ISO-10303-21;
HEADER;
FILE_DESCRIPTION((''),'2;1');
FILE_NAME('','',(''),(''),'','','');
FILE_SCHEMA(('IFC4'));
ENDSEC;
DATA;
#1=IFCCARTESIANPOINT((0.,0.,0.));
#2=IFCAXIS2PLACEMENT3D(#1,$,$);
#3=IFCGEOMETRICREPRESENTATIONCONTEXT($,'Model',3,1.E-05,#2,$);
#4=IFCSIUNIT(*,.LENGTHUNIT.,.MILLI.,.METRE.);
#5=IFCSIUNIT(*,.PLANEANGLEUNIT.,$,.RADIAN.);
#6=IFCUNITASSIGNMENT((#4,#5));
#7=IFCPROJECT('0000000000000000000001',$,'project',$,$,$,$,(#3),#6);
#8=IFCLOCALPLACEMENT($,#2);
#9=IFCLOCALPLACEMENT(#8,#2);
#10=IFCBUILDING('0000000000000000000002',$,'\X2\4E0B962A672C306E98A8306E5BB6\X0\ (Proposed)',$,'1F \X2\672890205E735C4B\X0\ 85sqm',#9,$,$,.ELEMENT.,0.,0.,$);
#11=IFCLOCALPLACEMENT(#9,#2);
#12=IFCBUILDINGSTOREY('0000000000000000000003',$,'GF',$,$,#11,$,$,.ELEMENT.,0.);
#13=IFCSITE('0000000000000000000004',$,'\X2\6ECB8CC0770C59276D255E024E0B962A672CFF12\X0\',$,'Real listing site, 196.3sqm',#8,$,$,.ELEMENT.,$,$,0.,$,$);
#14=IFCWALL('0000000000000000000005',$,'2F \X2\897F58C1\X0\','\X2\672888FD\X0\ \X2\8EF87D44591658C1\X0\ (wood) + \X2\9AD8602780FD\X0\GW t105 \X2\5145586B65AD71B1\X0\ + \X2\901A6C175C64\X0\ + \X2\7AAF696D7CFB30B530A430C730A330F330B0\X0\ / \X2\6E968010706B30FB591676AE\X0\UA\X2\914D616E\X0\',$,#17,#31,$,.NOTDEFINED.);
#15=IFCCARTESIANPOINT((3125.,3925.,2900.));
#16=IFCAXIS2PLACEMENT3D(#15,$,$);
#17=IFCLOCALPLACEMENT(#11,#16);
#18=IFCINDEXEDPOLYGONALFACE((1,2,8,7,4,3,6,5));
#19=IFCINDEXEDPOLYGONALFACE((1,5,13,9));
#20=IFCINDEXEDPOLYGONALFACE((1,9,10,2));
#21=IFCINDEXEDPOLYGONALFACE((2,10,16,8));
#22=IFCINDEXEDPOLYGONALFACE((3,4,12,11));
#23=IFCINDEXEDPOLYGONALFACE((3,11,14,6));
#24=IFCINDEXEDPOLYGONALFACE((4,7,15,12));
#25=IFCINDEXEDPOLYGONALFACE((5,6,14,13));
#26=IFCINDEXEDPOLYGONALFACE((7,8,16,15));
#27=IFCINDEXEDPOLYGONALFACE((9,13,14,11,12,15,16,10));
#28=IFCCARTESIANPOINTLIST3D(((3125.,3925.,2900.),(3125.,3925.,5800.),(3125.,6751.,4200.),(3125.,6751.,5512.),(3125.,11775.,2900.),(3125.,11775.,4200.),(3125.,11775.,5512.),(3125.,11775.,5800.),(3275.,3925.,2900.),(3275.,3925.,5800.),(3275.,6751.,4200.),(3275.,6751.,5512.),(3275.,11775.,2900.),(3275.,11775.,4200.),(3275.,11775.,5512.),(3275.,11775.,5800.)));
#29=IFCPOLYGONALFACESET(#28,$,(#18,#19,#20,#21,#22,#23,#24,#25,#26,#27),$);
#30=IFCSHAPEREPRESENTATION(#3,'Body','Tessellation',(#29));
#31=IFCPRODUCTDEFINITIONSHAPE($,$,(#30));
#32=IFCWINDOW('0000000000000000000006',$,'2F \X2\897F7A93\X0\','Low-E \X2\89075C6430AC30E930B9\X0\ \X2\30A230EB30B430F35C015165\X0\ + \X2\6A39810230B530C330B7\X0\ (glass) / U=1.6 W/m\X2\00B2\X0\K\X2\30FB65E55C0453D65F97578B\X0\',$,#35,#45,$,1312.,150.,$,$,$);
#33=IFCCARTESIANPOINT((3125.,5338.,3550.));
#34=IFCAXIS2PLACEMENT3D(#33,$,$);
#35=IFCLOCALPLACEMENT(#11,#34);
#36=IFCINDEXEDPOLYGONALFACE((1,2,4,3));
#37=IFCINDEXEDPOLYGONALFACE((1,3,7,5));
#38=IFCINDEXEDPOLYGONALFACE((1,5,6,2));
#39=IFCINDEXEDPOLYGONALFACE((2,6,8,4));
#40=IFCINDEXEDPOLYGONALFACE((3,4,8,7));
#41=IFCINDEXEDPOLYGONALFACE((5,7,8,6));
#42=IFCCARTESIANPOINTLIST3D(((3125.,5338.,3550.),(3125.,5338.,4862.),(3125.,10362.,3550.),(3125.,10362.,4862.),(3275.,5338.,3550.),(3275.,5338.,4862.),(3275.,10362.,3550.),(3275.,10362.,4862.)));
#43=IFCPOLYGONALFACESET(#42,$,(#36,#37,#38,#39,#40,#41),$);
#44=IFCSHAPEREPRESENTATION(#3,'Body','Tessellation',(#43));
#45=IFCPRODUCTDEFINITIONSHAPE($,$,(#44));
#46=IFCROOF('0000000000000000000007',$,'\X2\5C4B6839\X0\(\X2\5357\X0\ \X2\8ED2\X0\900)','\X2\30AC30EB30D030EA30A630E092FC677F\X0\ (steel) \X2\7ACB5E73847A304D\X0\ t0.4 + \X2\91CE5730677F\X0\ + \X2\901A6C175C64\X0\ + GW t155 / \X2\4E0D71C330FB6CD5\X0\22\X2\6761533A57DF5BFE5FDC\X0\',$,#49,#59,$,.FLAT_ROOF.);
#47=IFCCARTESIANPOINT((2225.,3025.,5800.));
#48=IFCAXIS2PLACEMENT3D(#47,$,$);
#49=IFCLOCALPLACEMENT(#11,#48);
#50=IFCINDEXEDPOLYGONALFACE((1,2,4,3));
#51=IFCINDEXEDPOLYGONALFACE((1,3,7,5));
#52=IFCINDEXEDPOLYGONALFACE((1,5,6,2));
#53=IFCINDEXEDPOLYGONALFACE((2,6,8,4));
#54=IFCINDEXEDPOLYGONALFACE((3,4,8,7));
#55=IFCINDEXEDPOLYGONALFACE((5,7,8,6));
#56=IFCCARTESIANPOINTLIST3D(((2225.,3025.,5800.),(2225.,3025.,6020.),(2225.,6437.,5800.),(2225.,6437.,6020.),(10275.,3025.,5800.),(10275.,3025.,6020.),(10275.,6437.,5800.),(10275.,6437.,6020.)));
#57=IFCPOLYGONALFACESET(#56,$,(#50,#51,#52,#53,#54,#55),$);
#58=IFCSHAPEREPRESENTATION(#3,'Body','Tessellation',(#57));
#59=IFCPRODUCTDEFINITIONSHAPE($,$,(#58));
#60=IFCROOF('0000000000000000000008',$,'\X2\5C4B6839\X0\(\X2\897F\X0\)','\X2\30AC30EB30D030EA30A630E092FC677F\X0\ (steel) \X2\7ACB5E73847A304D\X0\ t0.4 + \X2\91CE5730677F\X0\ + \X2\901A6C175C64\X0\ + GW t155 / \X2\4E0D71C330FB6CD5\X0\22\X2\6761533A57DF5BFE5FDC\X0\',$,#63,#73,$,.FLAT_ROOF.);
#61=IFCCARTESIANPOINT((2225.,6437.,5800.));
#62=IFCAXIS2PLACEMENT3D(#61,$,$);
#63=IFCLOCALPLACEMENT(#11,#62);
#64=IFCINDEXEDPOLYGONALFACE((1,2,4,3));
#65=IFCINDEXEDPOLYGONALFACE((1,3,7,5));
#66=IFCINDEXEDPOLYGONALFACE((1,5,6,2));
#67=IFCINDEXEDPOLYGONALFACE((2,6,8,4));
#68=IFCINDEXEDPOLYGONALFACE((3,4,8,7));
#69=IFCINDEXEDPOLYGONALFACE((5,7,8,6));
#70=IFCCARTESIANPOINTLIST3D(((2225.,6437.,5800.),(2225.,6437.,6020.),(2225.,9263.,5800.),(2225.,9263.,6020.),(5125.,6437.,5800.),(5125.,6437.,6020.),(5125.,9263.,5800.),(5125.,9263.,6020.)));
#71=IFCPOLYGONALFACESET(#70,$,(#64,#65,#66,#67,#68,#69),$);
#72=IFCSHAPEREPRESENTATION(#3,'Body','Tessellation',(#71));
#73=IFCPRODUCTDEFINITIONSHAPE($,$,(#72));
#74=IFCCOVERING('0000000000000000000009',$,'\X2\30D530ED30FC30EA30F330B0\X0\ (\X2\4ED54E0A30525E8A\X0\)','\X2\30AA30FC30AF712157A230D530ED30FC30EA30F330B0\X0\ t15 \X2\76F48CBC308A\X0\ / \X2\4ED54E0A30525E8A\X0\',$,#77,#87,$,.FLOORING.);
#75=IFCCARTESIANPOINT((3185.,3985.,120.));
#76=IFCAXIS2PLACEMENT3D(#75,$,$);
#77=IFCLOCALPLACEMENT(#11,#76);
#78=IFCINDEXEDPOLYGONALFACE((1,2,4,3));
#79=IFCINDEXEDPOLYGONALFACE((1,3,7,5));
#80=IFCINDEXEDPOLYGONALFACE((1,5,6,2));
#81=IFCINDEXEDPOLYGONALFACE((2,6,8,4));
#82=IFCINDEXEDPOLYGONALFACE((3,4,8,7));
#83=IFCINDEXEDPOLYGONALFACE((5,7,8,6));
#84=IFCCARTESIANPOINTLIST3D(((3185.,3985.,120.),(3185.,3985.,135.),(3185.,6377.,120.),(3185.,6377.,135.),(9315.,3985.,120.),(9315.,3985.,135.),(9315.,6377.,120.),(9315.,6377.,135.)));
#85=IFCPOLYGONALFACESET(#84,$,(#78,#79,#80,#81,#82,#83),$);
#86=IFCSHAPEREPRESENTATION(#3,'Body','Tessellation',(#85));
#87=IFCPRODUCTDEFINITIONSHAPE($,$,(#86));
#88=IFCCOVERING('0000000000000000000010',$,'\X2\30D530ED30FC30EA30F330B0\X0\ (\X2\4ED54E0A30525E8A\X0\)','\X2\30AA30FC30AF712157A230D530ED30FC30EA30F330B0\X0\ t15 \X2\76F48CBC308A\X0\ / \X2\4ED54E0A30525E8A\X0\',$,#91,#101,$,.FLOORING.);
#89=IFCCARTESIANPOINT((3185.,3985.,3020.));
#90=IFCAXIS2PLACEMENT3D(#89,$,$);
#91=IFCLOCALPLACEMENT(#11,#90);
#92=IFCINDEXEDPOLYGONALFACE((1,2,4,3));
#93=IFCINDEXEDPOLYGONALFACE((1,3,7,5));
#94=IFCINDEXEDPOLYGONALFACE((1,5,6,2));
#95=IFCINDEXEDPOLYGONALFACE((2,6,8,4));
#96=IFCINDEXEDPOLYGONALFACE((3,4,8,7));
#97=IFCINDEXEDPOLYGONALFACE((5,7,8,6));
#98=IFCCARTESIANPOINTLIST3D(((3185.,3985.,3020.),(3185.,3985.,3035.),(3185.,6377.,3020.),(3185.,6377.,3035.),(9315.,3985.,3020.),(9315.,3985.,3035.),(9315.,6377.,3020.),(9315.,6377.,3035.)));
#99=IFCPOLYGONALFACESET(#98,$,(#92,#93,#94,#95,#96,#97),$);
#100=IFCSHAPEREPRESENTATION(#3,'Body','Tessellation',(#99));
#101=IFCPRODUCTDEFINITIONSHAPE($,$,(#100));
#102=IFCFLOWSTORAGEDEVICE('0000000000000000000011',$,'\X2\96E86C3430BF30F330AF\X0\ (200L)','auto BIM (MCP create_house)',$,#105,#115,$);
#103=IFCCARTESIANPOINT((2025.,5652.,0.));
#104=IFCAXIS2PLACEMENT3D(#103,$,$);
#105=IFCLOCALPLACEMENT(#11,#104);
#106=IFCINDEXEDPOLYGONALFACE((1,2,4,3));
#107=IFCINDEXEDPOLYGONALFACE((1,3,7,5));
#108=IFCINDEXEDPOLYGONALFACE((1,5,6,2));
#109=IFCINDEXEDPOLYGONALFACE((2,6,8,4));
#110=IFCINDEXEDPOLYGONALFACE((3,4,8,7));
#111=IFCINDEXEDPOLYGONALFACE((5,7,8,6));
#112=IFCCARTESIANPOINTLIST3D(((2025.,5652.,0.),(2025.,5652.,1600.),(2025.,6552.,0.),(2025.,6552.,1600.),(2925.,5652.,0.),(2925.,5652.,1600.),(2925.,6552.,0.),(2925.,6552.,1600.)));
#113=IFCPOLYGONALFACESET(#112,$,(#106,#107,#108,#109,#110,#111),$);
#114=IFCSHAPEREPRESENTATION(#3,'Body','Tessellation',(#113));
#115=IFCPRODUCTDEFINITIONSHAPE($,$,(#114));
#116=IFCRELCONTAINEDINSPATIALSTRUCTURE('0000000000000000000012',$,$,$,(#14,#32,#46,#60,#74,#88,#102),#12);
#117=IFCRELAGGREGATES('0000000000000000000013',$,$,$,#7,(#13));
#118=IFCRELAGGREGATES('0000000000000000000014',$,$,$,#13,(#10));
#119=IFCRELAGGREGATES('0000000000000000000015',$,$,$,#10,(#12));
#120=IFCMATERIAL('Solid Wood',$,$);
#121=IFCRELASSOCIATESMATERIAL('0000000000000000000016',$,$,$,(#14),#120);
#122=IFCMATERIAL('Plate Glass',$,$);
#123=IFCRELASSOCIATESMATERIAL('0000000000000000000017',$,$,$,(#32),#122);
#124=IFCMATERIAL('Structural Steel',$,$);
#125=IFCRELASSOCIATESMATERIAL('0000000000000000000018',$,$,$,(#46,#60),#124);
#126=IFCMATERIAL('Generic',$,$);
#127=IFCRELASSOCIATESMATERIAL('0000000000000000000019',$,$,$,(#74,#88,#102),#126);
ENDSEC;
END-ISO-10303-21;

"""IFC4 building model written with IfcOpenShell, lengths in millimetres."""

from ifc_helpers import new_model, si_unit, frame, frame_2d, origin, place, context, project, spatial, rectangle, extrude, material, element, fill, save


model = new_model("IFC4")

# Units and contexts
model_context = context("Model", 3, precision=1e-05, world=origin())
ifc_project = project(units=[si_unit("LENGTHUNIT", "METRE", prefix="MILLI"), si_unit("PLANEANGLEUNIT", "RADIAN")], contexts=[model_context])

# Site, building, storey
site_placement = place(None, origin())
site = spatial("IfcSite", under=ifc_project, at=site_placement, Name="滋賀県大津市下阪本２", ObjectType="Real listing site, 196.3sqm", CompositionType="ELEMENT", RefElevation=0.0)
building_placement = place(site_placement, origin())
building = spatial("IfcBuilding", under=site, at=building_placement, Name="下阪本の風の家 (Proposed)", ObjectType="1F 木造平屋 85sqm", CompositionType="ELEMENT", ElevationOfRefHeight=0.0, ElevationOfTerrain=0.0)
storey_placement = place(building_placement, origin())
storey = spatial("IfcBuildingStorey", under=building, at=storey_placement, Name="GF", CompositionType="ELEMENT", Elevation=0.0)

# Shared definitions
ifc_material_1 = material(Name="Solid Wood")
ifc_material_2 = material(Name="Generic")

# Shared definitions
ifc_material_3 = material(Name="Plate Glass")

# Wall, opening, window
wall_1_placement = place(storey_placement, frame((3125.0, 3925.0, 2900.0)))
wall_1 = element("IfcWall", 1, at=wall_1_placement, inside=storey, material=ifc_material_1, Name="2F 西壁", Description="木製 軸組外壁 (wood) + 高性能GW t105 充填断熱 + 通気層 + 窯業系サイディング / 準耐火・外皮UA配慮", PredefinedType="NOTDEFINED", context=model_context, shape_type="SweptSolid", body=[
    extrude(rectangle(XDim=150.0, YDim=7850.0, at=frame_2d((75.0, 3925.0))), frame((3125.0, 3925.0, 2900.0)), (0.0, 0.0, 1.0), 2900.0),
])
opening_1_placement = place(storey_placement, frame((3125.0, 5338.0, 3550.0)))
opening_1 = element("IfcOpeningElement", 2, at=opening_1_placement, cuts=wall_1, PredefinedType="NOTDEFINED", context=model_context, shape_type="SweptSolid", body=[
    extrude(rectangle(XDim=150.0, YDim=5024.0, at=frame_2d((75.0, 2512.0))), frame((3125.0, 5338.0, 3550.0)), (0.0, 0.0, 1.0), 1312.0),
])
window_1_placement = place(storey_placement, frame((3125.0, 5338.0, 3550.0)))
window_1 = element("IfcWindow", 3, at=window_1_placement, inside=storey, material=ifc_material_3, Name="2F 西窓", Description="Low-E 複層ガラス アルゴン封入 + 樹脂サッシ (glass) / U=1.6 W/m²K・日射取得型", OverallHeight=1312.0, OverallWidth=150.0, context=model_context, shape_type="SweptSolid", body=[
    extrude(rectangle(XDim=150.0, YDim=5024.0, at=frame_2d((75.0, 2512.0))), frame((3125.0, 5338.0, 3550.0)), (0.0, 0.0, 1.0), 1312.0),
])
fill(opening_1, window_1)

# Roofs
ifc_material_4 = material(Name="Structural Steel")
roof_1_placement = place(storey_placement, frame((2225.0, 3025.0, 5800.0)))
element("IfcRoof", 4, at=roof_1_placement, inside=storey, material=ifc_material_4, Name="屋根(南 軒900)", Description="ガルバリウム鋼板 (steel) 立平葺き t0.4 + 野地板 + 通気層 + GW t155 / 不燃・法22条区域対応", PredefinedType="FLAT_ROOF", context=model_context, shape_type="SweptSolid", body=[
    extrude(rectangle(XDim=8050.0, YDim=3412.0, at=frame_2d((4025.0, 1706.0))), frame((2225.0, 3025.0, 5800.0)), (0.0, 0.0, 1.0), 220.0),
])
roof_2_placement = place(storey_placement, frame((2225.0, 6437.0, 5800.0)))
element("IfcRoof", 5, at=roof_2_placement, inside=storey, material=ifc_material_4, Name="屋根(西)", Description="ガルバリウム鋼板 (steel) 立平葺き t0.4 + 野地板 + 通気層 + GW t155 / 不燃・法22条区域対応", PredefinedType="FLAT_ROOF", context=model_context, shape_type="SweptSolid", body=[
    extrude(rectangle(XDim=2900.0, YDim=2826.0, at=frame_2d((1450.0, 1413.0))), frame((2225.0, 6437.0, 5800.0)), (0.0, 0.0, 1.0), 220.0),
])

# Coverings
covering_1_placement = place(storey_placement, frame((3185.0, 3985.0, 120.0)))
element("IfcCovering", 6, at=covering_1_placement, inside=storey, material=ifc_material_2, Name="フローリング (仕上げ床)", Description="オーク無垢フローリング t15 直貼り / 仕上げ床", PredefinedType="FLOORING", context=model_context, shape_type="SweptSolid", body=[
    extrude(rectangle(XDim=6130.0, YDim=2392.0, at=frame_2d((3065.0, 1196.0))), frame((3185.0, 3985.0, 120.0)), (0.0, 0.0, 1.0), 15.0),
])
covering_2_placement = place(storey_placement, frame((3185.0, 3985.0, 3020.0)))
element("IfcCovering", 7, at=covering_2_placement, inside=storey, material=ifc_material_2, Name="フローリング (仕上げ床)", Description="オーク無垢フローリング t15 直貼り / 仕上げ床", PredefinedType="FLOORING", context=model_context, shape_type="SweptSolid", body=[
    extrude(rectangle(XDim=6130.0, YDim=2392.0, at=frame_2d((3065.0, 1196.0))), frame((3185.0, 3985.0, 3020.0)), (0.0, 0.0, 1.0), 15.0),
])

# Flow storage device
flow_storage_device_placement = place(storey_placement, frame((2025.0, 5652.0, 0.0)))
element("IfcFlowStorageDevice", 8, at=flow_storage_device_placement, inside=storey, material=ifc_material_2, Name="雨水タンク (200L)", Description="auto BIM (MCP create_house)", context=model_context, shape_type="SweptSolid", body=[
    extrude(rectangle(XDim=900.0, YDim=900.0, at=frame_2d((450.0, 450.0))), frame((2025.0, 5652.0, 0.0)), (0.0, 0.0, 1.0), 1600.0),
])

save(model, "model.ifc")
